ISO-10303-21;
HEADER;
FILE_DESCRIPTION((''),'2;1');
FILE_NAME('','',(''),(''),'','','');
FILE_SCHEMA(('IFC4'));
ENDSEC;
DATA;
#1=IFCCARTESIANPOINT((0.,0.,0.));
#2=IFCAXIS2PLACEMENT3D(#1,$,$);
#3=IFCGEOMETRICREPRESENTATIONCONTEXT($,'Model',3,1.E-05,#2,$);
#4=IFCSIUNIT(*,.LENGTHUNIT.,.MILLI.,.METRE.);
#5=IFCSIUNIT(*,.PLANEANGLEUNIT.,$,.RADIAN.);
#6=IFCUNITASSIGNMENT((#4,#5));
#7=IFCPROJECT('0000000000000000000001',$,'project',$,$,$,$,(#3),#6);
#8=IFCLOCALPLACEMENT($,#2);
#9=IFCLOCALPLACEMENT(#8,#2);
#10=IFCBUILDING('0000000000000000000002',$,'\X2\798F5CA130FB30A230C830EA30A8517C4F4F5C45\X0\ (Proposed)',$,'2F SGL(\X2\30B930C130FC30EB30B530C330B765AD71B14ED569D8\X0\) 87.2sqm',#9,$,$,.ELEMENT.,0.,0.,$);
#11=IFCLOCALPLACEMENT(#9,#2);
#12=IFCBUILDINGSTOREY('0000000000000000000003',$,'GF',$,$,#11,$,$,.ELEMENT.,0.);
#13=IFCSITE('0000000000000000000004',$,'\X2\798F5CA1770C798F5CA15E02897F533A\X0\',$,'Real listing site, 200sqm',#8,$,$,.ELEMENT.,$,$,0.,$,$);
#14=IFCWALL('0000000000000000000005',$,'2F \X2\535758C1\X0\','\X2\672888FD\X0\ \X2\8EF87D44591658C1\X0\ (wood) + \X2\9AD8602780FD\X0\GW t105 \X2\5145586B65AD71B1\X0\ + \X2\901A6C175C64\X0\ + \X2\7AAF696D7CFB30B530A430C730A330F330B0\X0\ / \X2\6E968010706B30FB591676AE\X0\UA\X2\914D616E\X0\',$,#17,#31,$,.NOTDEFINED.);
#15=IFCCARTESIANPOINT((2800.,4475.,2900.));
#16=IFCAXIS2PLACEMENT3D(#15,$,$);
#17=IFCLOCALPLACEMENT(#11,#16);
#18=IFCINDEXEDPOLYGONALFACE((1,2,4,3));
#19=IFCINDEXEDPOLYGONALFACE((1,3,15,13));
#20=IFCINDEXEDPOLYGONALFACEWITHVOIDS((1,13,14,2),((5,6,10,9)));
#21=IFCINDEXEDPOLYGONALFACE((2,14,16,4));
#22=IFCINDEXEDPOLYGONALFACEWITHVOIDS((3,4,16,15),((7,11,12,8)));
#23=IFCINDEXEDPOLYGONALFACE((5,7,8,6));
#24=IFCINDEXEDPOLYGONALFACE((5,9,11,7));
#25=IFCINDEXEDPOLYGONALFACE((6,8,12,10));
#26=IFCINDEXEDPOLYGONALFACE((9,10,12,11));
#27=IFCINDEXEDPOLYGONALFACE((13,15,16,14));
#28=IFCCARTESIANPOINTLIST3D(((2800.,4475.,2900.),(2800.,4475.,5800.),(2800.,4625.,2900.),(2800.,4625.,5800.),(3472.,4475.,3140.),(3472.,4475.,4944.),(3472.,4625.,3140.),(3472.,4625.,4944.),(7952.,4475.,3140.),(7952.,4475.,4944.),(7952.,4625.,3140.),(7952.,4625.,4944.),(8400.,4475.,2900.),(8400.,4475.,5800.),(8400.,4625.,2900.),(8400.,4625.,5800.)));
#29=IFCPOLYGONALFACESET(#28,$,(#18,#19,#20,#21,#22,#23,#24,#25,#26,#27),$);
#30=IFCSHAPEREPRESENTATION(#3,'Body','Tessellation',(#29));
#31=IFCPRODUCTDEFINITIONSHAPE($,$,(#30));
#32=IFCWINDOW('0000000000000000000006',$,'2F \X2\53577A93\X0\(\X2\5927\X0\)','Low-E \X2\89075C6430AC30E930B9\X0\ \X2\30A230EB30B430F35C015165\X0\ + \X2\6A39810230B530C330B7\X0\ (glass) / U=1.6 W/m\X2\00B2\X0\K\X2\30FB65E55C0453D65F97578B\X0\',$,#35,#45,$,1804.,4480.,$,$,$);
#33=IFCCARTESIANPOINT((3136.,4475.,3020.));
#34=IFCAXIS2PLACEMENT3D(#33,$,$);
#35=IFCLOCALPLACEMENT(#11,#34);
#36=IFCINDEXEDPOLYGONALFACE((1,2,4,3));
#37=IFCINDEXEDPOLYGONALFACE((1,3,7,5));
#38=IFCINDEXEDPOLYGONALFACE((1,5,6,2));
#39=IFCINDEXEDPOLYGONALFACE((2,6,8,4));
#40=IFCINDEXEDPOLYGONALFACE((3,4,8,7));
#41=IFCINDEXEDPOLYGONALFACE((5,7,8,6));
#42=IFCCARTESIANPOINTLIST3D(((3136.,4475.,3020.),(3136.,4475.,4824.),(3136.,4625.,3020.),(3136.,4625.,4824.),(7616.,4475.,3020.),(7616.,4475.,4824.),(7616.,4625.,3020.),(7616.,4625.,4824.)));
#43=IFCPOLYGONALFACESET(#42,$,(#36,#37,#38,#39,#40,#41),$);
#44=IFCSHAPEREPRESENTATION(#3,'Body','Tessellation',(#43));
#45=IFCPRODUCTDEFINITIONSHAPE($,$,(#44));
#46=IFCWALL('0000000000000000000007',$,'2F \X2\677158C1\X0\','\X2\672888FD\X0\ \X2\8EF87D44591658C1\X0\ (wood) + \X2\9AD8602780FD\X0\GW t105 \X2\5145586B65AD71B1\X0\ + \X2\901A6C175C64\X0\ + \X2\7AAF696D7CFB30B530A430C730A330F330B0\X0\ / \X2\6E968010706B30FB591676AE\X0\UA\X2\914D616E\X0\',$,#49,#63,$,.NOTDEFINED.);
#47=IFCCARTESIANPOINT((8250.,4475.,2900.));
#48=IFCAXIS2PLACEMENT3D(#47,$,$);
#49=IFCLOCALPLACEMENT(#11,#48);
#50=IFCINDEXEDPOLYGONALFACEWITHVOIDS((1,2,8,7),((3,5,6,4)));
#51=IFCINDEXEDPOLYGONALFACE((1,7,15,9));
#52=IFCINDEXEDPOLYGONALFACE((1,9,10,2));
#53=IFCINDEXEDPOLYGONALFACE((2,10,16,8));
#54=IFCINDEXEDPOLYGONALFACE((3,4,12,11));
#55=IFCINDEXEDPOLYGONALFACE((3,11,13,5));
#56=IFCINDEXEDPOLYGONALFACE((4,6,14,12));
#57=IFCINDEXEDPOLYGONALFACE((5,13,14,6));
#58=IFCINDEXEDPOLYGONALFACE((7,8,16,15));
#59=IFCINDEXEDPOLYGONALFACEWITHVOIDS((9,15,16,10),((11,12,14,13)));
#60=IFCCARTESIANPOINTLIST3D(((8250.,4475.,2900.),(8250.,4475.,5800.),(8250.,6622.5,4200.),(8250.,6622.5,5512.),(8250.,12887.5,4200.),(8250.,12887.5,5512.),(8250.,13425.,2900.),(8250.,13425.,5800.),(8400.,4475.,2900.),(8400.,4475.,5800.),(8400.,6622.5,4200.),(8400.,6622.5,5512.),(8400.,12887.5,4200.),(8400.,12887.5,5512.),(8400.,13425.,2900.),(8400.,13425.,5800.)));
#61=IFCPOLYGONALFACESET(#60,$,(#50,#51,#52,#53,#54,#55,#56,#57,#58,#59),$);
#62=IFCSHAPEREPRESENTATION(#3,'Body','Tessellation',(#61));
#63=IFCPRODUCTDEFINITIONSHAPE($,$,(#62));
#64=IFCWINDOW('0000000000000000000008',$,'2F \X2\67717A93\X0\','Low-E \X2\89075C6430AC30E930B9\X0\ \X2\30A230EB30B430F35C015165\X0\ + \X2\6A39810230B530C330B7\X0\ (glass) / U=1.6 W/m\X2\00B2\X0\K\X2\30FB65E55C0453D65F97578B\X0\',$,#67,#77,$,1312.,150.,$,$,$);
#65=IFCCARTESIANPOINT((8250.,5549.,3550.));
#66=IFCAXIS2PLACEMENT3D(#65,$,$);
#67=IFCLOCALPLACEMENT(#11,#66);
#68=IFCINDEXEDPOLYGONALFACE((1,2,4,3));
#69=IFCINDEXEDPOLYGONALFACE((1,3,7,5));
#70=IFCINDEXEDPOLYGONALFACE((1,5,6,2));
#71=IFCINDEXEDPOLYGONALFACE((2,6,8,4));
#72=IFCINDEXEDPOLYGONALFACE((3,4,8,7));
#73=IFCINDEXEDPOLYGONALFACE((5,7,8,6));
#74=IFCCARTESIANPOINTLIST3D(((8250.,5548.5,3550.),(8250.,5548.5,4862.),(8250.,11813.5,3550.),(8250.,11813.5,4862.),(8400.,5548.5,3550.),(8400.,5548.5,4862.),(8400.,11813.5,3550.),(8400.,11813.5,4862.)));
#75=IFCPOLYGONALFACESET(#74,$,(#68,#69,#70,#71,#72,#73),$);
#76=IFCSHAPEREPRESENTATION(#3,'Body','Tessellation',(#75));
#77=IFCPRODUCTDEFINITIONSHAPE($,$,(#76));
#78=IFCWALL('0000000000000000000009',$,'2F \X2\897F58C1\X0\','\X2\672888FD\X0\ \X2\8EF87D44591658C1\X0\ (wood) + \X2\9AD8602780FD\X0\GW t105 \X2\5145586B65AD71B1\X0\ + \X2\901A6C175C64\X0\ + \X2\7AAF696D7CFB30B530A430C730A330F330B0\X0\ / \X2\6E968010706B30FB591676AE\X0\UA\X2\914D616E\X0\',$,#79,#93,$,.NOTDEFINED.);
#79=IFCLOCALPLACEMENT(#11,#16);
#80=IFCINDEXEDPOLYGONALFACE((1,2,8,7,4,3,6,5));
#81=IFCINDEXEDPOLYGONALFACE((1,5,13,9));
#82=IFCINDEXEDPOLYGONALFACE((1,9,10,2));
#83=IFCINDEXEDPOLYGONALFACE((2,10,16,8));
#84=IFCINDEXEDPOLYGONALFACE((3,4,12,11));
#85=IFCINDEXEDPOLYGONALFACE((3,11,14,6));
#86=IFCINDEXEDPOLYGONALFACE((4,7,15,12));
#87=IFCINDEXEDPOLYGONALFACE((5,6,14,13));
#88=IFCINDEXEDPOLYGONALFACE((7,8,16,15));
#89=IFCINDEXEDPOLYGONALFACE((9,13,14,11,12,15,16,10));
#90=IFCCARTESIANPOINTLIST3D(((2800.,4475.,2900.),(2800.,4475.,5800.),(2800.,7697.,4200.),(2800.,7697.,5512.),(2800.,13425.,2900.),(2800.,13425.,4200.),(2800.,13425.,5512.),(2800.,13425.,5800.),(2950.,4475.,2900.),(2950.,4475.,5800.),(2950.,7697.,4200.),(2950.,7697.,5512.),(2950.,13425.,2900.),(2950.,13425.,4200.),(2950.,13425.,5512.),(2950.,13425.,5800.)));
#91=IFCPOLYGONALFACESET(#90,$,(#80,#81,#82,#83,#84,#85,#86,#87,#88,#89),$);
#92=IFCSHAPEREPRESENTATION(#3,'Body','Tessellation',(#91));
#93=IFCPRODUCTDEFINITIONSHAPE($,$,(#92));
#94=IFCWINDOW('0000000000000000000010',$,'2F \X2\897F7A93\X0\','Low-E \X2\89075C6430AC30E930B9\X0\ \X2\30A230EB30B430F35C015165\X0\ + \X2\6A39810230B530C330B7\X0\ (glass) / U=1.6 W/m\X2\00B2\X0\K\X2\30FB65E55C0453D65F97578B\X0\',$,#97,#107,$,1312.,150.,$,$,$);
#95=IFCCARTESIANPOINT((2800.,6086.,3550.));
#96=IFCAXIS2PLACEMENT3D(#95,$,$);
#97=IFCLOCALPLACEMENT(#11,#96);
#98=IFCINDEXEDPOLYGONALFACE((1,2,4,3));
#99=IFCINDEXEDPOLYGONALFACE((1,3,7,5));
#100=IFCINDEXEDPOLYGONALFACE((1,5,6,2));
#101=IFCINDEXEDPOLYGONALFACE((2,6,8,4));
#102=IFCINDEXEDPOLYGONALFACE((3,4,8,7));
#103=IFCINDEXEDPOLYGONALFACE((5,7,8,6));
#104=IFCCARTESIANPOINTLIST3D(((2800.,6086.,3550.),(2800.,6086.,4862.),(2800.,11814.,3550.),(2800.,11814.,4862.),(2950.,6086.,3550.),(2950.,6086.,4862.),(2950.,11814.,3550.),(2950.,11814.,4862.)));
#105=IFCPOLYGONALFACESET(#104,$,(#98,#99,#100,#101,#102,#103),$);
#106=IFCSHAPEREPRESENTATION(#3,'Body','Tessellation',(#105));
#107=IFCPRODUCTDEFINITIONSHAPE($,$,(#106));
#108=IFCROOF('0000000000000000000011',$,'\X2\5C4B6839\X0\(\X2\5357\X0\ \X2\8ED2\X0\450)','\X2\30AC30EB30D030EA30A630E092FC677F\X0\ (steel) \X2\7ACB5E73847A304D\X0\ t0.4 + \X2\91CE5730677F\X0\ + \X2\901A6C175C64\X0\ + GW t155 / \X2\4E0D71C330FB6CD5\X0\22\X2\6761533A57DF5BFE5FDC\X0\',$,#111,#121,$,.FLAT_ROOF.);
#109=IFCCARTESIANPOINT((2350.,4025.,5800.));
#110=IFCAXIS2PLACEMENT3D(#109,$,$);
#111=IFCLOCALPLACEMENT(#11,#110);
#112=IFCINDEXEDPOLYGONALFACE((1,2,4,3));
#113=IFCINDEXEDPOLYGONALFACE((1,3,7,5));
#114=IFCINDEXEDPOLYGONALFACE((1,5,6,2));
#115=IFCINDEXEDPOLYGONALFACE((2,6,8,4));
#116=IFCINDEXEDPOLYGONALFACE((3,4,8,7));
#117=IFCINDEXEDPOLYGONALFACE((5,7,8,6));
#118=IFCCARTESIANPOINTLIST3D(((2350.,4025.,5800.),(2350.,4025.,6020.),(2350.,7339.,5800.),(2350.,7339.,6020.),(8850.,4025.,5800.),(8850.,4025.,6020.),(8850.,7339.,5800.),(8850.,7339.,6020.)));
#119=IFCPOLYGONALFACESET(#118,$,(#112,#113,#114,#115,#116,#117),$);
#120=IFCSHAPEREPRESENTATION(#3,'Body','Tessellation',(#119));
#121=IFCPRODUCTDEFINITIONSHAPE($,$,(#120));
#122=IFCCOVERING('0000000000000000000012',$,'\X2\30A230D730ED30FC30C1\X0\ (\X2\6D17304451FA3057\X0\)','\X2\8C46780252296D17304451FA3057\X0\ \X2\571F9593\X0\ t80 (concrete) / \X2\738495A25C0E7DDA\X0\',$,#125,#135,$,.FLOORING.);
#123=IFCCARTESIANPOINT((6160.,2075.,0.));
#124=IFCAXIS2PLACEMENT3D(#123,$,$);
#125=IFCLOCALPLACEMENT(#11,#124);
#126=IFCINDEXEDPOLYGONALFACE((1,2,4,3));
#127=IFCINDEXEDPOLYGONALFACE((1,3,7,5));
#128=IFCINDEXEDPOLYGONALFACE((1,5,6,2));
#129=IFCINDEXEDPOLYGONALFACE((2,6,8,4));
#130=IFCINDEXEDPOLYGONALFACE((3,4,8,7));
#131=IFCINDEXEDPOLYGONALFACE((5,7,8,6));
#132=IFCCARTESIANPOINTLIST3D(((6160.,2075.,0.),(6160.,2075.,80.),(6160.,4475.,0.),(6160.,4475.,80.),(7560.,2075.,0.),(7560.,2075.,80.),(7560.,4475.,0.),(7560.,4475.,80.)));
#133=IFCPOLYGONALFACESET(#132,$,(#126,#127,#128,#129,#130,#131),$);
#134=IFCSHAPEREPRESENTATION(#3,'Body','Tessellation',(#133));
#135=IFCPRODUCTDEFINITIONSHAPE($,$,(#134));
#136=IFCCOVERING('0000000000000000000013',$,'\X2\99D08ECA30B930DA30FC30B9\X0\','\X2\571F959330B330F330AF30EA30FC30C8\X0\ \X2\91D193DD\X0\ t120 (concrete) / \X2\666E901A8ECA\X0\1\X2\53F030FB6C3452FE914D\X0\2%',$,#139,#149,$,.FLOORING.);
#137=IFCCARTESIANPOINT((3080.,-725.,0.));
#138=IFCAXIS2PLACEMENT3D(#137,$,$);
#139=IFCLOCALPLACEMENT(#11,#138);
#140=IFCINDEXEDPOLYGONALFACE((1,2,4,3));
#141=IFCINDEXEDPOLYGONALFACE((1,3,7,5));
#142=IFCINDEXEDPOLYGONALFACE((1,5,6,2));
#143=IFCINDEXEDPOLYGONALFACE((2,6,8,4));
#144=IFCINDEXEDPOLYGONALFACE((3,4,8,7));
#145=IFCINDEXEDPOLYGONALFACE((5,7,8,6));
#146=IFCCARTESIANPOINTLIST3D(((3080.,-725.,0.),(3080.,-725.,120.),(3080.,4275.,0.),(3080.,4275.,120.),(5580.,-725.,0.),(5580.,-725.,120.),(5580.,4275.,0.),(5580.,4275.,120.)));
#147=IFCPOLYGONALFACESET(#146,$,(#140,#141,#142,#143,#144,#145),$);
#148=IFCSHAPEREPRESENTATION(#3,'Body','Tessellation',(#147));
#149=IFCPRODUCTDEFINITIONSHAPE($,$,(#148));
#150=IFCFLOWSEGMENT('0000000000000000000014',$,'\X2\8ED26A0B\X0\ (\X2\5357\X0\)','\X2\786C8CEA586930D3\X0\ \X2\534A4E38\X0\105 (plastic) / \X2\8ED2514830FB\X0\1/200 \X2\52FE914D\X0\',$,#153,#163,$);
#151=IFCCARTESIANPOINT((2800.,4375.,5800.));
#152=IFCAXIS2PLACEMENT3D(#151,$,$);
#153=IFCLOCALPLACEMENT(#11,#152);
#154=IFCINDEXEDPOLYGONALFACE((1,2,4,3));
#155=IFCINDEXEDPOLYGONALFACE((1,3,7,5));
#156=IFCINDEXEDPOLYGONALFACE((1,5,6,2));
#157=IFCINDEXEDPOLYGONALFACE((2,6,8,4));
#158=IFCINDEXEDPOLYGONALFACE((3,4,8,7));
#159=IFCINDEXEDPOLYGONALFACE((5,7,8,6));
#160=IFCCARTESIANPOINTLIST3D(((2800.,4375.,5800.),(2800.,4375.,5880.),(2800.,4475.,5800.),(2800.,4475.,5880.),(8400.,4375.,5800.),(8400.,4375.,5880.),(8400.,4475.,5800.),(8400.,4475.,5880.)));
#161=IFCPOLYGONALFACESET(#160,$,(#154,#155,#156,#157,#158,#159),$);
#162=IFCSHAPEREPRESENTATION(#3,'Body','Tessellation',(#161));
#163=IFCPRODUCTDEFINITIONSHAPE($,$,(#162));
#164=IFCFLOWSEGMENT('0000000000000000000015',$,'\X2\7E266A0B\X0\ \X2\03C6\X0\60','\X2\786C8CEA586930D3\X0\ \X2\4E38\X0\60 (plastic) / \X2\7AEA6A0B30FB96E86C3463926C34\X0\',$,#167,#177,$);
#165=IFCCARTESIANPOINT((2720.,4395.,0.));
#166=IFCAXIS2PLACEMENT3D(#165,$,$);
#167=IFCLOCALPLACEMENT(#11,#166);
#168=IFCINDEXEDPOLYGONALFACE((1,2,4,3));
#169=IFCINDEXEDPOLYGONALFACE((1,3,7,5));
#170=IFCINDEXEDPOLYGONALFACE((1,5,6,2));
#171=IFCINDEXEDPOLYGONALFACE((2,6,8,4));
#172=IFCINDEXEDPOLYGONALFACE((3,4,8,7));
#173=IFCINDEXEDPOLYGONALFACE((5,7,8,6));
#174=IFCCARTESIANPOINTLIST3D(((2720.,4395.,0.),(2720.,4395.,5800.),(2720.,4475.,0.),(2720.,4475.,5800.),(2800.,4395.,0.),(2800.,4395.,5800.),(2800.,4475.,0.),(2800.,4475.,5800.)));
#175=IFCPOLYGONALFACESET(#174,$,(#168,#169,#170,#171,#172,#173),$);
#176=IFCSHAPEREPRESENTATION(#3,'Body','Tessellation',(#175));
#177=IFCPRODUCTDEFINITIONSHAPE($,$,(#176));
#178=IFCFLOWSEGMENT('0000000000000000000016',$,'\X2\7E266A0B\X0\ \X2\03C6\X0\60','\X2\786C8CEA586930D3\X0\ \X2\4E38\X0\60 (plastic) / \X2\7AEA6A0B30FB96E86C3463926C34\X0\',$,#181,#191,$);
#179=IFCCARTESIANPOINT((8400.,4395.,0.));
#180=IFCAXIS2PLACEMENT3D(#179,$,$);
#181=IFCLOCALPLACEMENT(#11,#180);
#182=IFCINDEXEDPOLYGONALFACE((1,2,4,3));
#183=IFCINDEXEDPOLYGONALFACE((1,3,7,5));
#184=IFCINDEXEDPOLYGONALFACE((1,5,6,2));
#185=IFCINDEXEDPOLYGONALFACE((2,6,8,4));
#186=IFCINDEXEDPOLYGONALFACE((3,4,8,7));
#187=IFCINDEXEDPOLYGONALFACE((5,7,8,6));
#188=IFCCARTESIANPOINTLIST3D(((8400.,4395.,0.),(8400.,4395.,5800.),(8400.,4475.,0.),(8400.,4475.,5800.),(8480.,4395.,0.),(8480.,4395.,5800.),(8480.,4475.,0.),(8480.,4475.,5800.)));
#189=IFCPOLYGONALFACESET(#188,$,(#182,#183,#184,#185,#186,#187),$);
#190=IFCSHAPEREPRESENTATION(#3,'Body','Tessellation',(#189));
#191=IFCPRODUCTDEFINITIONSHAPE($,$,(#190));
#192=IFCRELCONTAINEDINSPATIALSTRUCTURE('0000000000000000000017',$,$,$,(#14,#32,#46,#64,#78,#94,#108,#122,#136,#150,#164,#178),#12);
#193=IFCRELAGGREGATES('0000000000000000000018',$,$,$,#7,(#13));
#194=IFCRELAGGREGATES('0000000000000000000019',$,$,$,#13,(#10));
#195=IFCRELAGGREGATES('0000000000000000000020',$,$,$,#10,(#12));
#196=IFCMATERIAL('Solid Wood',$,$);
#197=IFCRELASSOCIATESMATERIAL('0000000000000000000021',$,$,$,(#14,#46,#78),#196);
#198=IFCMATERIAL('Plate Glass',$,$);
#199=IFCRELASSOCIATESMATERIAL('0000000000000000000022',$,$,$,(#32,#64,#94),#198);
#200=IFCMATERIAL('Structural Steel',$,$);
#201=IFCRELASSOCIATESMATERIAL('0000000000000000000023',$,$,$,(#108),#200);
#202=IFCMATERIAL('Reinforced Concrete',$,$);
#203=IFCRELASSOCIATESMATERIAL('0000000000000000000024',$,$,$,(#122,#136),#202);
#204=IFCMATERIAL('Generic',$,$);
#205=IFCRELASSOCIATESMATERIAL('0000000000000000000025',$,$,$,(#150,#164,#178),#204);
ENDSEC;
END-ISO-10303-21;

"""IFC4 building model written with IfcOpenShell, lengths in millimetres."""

from ifc_helpers import new_model, si_unit, frame, frame_2d, origin, place, context, project, spatial, rectangle, extrude, material, element, fill, save


model = new_model("IFC4")

# Units and contexts
model_context = context("Model", 3, precision=1e-05, world=origin())
ifc_project = project(units=[si_unit("LENGTHUNIT", "METRE", prefix="MILLI"), si_unit("PLANEANGLEUNIT", "RADIAN")], contexts=[model_context])

# Site, building, storey
site_placement = place(None, origin())
site = spatial("IfcSite", under=ifc_project, at=site_placement, Name="福岡県福岡市西区", ObjectType="Real listing site, 200sqm", CompositionType="ELEMENT", RefElevation=0.0)
building_placement = place(site_placement, origin())
building = spatial("IfcBuilding", under=site, at=building_placement, Name="福岡・アトリエ兼住居 (Proposed)", ObjectType="2F SGL(スチールサッシ断熱仕様) 87.2sqm", CompositionType="ELEMENT", ElevationOfRefHeight=0.0, ElevationOfTerrain=0.0)
storey_placement = place(building_placement, origin())
storey = spatial("IfcBuildingStorey", under=building, at=storey_placement, Name="GF", CompositionType="ELEMENT", Elevation=0.0)

# Shared definitions
ifc_material_1 = material(Name="Solid Wood")

# Shared definitions
ifc_material_2 = material(Name="Reinforced Concrete")

# Shared definitions
ifc_material_3 = material(Name="Plate Glass")

# Walls, openings, windows
wall_1_placement = place(storey_placement, frame((2800.0, 4475.0, 2900.0)))
wall_1 = element("IfcWall", 1, at=wall_1_placement, inside=storey, material=ifc_material_1, Name="2F 南壁", Description="木製 軸組外壁 (wood) + 高性能GW t105 充填断熱 + 通気層 + 窯業系サイディング / 準耐火・外皮UA配慮", PredefinedType="NOTDEFINED", context=model_context, shape_type="SweptSolid", body=[
    extrude(rectangle(XDim=5600.0, YDim=150.0, at=frame_2d((2800.0, 75.0))), frame((2800.0, 4475.0, 2900.0)), (0.0, 0.0, 1.0), 2900.0),
])
opening_1_placement = place(storey_placement, frame((3136.0, 4475.0, 3020.0)))
opening_1 = element("IfcOpeningElement", 2, at=opening_1_placement, cuts=wall_1, PredefinedType="NOTDEFINED", context=model_context, shape_type="SweptSolid", body=[
    extrude(rectangle(XDim=4480.0, YDim=150.0, at=frame_2d((2240.0, 75.0))), frame((3136.0, 4475.0, 3020.0)), (0.0, 0.0, 1.0), 1804.0),
])
window_1_placement = place(storey_placement, frame((3136.0, 4475.0, 3020.0)))
window_1 = element("IfcWindow", 3, at=window_1_placement, inside=storey, material=ifc_material_3, Name="2F 南窓(大)", Description="Low-E 複層ガラス アルゴン封入 + 樹脂サッシ (glass) / U=1.6 W/m²K・日射取得型", OverallHeight=1804.0, OverallWidth=4480.0, context=model_context, shape_type="SweptSolid", body=[
    extrude(rectangle(XDim=4480.0, YDim=150.0, at=frame_2d((2240.0, 75.0))), frame((3136.0, 4475.0, 3020.0)), (0.0, 0.0, 1.0), 1804.0),
])
fill(opening_1, window_1)
wall_2_placement = place(storey_placement, frame((8250.0, 4475.0, 2900.0)))
wall_2 = element("IfcWall", 4, at=wall_2_placement, inside=storey, material=ifc_material_1, Name="2F 東壁", Description="木製 軸組外壁 (wood) + 高性能GW t105 充填断熱 + 通気層 + 窯業系サイディング / 準耐火・外皮UA配慮", PredefinedType="NOTDEFINED", context=model_context, shape_type="SweptSolid", body=[
    extrude(rectangle(XDim=150.0, YDim=8950.0, at=frame_2d((75.0, 4475.0))), frame((8250.0, 4475.0, 2900.0)), (0.0, 0.0, 1.0), 2900.0),
])
opening_2_placement = place(storey_placement, frame((8250.0, 5549.0, 3550.0)))
opening_2 = element("IfcOpeningElement", 5, at=opening_2_placement, cuts=wall_2, PredefinedType="NOTDEFINED", context=model_context, shape_type="SweptSolid", body=[
    extrude(rectangle(XDim=150.0, YDim=6265.0, at=frame_2d((75.0, 3132.0))), frame((8250.0, 5549.0, 3550.0)), (0.0, 0.0, 1.0), 1312.0),
])
window_2_placement = place(storey_placement, frame((8250.0, 5549.0, 3550.0)))
window_2 = element("IfcWindow", 6, at=window_2_placement, inside=storey, material=ifc_material_3, Name="2F 東窓", Description="Low-E 複層ガラス アルゴン封入 + 樹脂サッシ (glass) / U=1.6 W/m²K・日射取得型", OverallHeight=1312.0, OverallWidth=150.0, context=model_context, shape_type="SweptSolid", body=[
    extrude(rectangle(XDim=150.0, YDim=6265.0, at=frame_2d((75.0, 3132.0))), frame((8250.0, 5549.0, 3550.0)), (0.0, 0.0, 1.0), 1312.0),
])
fill(opening_2, window_2)
wall_3_placement = place(storey_placement, frame((2800.0, 4475.0, 2900.0)))
wall_3 = element("IfcWall", 7, at=wall_3_placement, inside=storey, material=ifc_material_1, Name="2F 西壁", Description="木製 軸組外壁 (wood) + 高性能GW t105 充填断熱 + 通気層 + 窯業系サイディング / 準耐火・外皮UA配慮", PredefinedType="NOTDEFINED", context=model_context, shape_type="SweptSolid", body=[
    extrude(rectangle(XDim=150.0, YDim=8950.0, at=frame_2d((75.0, 4475.0))), frame((2800.0, 4475.0, 2900.0)), (0.0, 0.0, 1.0), 2900.0),
])
opening_3_placement = place(storey_placement, frame((2800.0, 6086.0, 3550.0)))
opening_3 = element("IfcOpeningElement", 8, at=opening_3_placement, cuts=wall_3, PredefinedType="NOTDEFINED", context=model_context, shape_type="SweptSolid", body=[
    extrude(rectangle(XDim=150.0, YDim=5728.0, at=frame_2d((75.0, 2864.0))), frame((2800.0, 6086.0, 3550.0)), (0.0, 0.0, 1.0), 1312.0),
])
window_3_placement = place(storey_placement, frame((2800.0, 6086.0, 3550.0)))
window_3 = element("IfcWindow", 9, at=window_3_placement, inside=storey, material=ifc_material_3, Name="2F 西窓", Description="Low-E 複層ガラス アルゴン封入 + 樹脂サッシ (glass) / U=1.6 W/m²K・日射取得型", OverallHeight=1312.0, OverallWidth=150.0, context=model_context, shape_type="SweptSolid", body=[
    extrude(rectangle(XDim=150.0, YDim=5728.0, at=frame_2d((75.0, 2864.0))), frame((2800.0, 6086.0, 3550.0)), (0.0, 0.0, 1.0), 1312.0),
])
fill(opening_3, window_3)

# Roof
ifc_material_4 = material(Name="Structural Steel")
for number, where, name in (
    (10, (2350.0, 4025.0, 5800.0), "屋根(南 軒450)"),
):
    element("IfcRoof", number, at=place(storey_placement, frame(where)), inside=storey, material=ifc_material_4, Name=name, Description="ガルバリウム鋼板 (steel) 立平葺き t0.4 + 野地板 + 通気層 + GW t155 / 不燃・法22条区域対応", PredefinedType="FLAT_ROOF", context=model_context, shape_type="SweptSolid", body=[
        extrude(rectangle(XDim=6500.0, YDim=3314.0, at=frame_2d((3250.0, 1657.0))), frame((2350.0, 4025.0, 5800.0)), (0.0, 0.0, 1.0), 220.0),
    ])

# Coverings
covering_1_placement = place(storey_placement, frame((6160.0, 2075.0, 0.0)))
element("IfcCovering", 11, at=covering_1_placement, inside=storey, material=ifc_material_2, Name="アプローチ (洗い出し)", Description="豆砂利洗い出し 土間 t80 (concrete) / 玄関導線", PredefinedType="FLOORING", context=model_context, shape_type="SweptSolid", body=[
    extrude(rectangle(XDim=1400.0, YDim=2400.0, at=frame_2d((700.0, 1200.0))), frame((6160.0, 2075.0, 0.0)), (0.0, 0.0, 1.0), 80.0),
])
covering_2_placement = place(storey_placement, frame((3080.0, -725.0, 0.0)))
element("IfcCovering", 12, at=covering_2_placement, inside=storey, material=ifc_material_2, Name="駐車スペース", Description="土間コンクリート 金鏝 t120 (concrete) / 普通車1台・水勾配2%", PredefinedType="FLOORING", context=model_context, shape_type="SweptSolid", body=[
    extrude(rectangle(XDim=2500.0, YDim=5000.0, at=frame_2d((1250.0, 2500.0))), frame((3080.0, -725.0, 0.0)), (0.0, 0.0, 1.0), 120.0),
])

# Flow segments
ifc_material_5 = material(Name="Generic")
flow_segment_1_placement = place(storey_placement, frame((2800.0, 4375.0, 5800.0)))
element("IfcFlowSegment", 13, at=flow_segment_1_placement, inside=storey, material=ifc_material_5, Name="軒樋 (南)", Description="硬質塩ビ 半丸105 (plastic) / 軒先・1/200 勾配", context=model_context, shape_type="SweptSolid", body=[
    extrude(rectangle(XDim=5600.0, YDim=100.0, at=frame_2d((2800.0, 50.0))), frame((2800.0, 4375.0, 5800.0)), (0.0, 0.0, 1.0), 80.0),
])
flow_segment_2_placement = place(storey_placement, frame((2720.0, 4395.0, 0.0)))
element("IfcFlowSegment", 14, at=flow_segment_2_placement, inside=storey, material=ifc_material_5, Name="縦樋 φ60", Description="硬質塩ビ 丸60 (plastic) / 竪樋・雨水排水", context=model_context, shape_type="SweptSolid", body=[
    extrude(rectangle(XDim=80.0, YDim=80.0, at=frame_2d((40.0, 40.0))), frame((2720.0, 4395.0, 0.0)), (0.0, 0.0, 1.0), 5800.0),
])
flow_segment_3_placement = place(storey_placement, frame((8400.0, 4395.0, 0.0)))
element("IfcFlowSegment", 15, at=flow_segment_3_placement, inside=storey, material=ifc_material_5, Name="縦樋 φ60", Description="硬質塩ビ 丸60 (plastic) / 竪樋・雨水排水", context=model_context, shape_type="SweptSolid", body=[
    extrude(rectangle(XDim=80.0, YDim=80.0, at=frame_2d((40.0, 40.0))), frame((8400.0, 4395.0, 0.0)), (0.0, 0.0, 1.0), 5800.0),
])

save(model, "model.ifc")
